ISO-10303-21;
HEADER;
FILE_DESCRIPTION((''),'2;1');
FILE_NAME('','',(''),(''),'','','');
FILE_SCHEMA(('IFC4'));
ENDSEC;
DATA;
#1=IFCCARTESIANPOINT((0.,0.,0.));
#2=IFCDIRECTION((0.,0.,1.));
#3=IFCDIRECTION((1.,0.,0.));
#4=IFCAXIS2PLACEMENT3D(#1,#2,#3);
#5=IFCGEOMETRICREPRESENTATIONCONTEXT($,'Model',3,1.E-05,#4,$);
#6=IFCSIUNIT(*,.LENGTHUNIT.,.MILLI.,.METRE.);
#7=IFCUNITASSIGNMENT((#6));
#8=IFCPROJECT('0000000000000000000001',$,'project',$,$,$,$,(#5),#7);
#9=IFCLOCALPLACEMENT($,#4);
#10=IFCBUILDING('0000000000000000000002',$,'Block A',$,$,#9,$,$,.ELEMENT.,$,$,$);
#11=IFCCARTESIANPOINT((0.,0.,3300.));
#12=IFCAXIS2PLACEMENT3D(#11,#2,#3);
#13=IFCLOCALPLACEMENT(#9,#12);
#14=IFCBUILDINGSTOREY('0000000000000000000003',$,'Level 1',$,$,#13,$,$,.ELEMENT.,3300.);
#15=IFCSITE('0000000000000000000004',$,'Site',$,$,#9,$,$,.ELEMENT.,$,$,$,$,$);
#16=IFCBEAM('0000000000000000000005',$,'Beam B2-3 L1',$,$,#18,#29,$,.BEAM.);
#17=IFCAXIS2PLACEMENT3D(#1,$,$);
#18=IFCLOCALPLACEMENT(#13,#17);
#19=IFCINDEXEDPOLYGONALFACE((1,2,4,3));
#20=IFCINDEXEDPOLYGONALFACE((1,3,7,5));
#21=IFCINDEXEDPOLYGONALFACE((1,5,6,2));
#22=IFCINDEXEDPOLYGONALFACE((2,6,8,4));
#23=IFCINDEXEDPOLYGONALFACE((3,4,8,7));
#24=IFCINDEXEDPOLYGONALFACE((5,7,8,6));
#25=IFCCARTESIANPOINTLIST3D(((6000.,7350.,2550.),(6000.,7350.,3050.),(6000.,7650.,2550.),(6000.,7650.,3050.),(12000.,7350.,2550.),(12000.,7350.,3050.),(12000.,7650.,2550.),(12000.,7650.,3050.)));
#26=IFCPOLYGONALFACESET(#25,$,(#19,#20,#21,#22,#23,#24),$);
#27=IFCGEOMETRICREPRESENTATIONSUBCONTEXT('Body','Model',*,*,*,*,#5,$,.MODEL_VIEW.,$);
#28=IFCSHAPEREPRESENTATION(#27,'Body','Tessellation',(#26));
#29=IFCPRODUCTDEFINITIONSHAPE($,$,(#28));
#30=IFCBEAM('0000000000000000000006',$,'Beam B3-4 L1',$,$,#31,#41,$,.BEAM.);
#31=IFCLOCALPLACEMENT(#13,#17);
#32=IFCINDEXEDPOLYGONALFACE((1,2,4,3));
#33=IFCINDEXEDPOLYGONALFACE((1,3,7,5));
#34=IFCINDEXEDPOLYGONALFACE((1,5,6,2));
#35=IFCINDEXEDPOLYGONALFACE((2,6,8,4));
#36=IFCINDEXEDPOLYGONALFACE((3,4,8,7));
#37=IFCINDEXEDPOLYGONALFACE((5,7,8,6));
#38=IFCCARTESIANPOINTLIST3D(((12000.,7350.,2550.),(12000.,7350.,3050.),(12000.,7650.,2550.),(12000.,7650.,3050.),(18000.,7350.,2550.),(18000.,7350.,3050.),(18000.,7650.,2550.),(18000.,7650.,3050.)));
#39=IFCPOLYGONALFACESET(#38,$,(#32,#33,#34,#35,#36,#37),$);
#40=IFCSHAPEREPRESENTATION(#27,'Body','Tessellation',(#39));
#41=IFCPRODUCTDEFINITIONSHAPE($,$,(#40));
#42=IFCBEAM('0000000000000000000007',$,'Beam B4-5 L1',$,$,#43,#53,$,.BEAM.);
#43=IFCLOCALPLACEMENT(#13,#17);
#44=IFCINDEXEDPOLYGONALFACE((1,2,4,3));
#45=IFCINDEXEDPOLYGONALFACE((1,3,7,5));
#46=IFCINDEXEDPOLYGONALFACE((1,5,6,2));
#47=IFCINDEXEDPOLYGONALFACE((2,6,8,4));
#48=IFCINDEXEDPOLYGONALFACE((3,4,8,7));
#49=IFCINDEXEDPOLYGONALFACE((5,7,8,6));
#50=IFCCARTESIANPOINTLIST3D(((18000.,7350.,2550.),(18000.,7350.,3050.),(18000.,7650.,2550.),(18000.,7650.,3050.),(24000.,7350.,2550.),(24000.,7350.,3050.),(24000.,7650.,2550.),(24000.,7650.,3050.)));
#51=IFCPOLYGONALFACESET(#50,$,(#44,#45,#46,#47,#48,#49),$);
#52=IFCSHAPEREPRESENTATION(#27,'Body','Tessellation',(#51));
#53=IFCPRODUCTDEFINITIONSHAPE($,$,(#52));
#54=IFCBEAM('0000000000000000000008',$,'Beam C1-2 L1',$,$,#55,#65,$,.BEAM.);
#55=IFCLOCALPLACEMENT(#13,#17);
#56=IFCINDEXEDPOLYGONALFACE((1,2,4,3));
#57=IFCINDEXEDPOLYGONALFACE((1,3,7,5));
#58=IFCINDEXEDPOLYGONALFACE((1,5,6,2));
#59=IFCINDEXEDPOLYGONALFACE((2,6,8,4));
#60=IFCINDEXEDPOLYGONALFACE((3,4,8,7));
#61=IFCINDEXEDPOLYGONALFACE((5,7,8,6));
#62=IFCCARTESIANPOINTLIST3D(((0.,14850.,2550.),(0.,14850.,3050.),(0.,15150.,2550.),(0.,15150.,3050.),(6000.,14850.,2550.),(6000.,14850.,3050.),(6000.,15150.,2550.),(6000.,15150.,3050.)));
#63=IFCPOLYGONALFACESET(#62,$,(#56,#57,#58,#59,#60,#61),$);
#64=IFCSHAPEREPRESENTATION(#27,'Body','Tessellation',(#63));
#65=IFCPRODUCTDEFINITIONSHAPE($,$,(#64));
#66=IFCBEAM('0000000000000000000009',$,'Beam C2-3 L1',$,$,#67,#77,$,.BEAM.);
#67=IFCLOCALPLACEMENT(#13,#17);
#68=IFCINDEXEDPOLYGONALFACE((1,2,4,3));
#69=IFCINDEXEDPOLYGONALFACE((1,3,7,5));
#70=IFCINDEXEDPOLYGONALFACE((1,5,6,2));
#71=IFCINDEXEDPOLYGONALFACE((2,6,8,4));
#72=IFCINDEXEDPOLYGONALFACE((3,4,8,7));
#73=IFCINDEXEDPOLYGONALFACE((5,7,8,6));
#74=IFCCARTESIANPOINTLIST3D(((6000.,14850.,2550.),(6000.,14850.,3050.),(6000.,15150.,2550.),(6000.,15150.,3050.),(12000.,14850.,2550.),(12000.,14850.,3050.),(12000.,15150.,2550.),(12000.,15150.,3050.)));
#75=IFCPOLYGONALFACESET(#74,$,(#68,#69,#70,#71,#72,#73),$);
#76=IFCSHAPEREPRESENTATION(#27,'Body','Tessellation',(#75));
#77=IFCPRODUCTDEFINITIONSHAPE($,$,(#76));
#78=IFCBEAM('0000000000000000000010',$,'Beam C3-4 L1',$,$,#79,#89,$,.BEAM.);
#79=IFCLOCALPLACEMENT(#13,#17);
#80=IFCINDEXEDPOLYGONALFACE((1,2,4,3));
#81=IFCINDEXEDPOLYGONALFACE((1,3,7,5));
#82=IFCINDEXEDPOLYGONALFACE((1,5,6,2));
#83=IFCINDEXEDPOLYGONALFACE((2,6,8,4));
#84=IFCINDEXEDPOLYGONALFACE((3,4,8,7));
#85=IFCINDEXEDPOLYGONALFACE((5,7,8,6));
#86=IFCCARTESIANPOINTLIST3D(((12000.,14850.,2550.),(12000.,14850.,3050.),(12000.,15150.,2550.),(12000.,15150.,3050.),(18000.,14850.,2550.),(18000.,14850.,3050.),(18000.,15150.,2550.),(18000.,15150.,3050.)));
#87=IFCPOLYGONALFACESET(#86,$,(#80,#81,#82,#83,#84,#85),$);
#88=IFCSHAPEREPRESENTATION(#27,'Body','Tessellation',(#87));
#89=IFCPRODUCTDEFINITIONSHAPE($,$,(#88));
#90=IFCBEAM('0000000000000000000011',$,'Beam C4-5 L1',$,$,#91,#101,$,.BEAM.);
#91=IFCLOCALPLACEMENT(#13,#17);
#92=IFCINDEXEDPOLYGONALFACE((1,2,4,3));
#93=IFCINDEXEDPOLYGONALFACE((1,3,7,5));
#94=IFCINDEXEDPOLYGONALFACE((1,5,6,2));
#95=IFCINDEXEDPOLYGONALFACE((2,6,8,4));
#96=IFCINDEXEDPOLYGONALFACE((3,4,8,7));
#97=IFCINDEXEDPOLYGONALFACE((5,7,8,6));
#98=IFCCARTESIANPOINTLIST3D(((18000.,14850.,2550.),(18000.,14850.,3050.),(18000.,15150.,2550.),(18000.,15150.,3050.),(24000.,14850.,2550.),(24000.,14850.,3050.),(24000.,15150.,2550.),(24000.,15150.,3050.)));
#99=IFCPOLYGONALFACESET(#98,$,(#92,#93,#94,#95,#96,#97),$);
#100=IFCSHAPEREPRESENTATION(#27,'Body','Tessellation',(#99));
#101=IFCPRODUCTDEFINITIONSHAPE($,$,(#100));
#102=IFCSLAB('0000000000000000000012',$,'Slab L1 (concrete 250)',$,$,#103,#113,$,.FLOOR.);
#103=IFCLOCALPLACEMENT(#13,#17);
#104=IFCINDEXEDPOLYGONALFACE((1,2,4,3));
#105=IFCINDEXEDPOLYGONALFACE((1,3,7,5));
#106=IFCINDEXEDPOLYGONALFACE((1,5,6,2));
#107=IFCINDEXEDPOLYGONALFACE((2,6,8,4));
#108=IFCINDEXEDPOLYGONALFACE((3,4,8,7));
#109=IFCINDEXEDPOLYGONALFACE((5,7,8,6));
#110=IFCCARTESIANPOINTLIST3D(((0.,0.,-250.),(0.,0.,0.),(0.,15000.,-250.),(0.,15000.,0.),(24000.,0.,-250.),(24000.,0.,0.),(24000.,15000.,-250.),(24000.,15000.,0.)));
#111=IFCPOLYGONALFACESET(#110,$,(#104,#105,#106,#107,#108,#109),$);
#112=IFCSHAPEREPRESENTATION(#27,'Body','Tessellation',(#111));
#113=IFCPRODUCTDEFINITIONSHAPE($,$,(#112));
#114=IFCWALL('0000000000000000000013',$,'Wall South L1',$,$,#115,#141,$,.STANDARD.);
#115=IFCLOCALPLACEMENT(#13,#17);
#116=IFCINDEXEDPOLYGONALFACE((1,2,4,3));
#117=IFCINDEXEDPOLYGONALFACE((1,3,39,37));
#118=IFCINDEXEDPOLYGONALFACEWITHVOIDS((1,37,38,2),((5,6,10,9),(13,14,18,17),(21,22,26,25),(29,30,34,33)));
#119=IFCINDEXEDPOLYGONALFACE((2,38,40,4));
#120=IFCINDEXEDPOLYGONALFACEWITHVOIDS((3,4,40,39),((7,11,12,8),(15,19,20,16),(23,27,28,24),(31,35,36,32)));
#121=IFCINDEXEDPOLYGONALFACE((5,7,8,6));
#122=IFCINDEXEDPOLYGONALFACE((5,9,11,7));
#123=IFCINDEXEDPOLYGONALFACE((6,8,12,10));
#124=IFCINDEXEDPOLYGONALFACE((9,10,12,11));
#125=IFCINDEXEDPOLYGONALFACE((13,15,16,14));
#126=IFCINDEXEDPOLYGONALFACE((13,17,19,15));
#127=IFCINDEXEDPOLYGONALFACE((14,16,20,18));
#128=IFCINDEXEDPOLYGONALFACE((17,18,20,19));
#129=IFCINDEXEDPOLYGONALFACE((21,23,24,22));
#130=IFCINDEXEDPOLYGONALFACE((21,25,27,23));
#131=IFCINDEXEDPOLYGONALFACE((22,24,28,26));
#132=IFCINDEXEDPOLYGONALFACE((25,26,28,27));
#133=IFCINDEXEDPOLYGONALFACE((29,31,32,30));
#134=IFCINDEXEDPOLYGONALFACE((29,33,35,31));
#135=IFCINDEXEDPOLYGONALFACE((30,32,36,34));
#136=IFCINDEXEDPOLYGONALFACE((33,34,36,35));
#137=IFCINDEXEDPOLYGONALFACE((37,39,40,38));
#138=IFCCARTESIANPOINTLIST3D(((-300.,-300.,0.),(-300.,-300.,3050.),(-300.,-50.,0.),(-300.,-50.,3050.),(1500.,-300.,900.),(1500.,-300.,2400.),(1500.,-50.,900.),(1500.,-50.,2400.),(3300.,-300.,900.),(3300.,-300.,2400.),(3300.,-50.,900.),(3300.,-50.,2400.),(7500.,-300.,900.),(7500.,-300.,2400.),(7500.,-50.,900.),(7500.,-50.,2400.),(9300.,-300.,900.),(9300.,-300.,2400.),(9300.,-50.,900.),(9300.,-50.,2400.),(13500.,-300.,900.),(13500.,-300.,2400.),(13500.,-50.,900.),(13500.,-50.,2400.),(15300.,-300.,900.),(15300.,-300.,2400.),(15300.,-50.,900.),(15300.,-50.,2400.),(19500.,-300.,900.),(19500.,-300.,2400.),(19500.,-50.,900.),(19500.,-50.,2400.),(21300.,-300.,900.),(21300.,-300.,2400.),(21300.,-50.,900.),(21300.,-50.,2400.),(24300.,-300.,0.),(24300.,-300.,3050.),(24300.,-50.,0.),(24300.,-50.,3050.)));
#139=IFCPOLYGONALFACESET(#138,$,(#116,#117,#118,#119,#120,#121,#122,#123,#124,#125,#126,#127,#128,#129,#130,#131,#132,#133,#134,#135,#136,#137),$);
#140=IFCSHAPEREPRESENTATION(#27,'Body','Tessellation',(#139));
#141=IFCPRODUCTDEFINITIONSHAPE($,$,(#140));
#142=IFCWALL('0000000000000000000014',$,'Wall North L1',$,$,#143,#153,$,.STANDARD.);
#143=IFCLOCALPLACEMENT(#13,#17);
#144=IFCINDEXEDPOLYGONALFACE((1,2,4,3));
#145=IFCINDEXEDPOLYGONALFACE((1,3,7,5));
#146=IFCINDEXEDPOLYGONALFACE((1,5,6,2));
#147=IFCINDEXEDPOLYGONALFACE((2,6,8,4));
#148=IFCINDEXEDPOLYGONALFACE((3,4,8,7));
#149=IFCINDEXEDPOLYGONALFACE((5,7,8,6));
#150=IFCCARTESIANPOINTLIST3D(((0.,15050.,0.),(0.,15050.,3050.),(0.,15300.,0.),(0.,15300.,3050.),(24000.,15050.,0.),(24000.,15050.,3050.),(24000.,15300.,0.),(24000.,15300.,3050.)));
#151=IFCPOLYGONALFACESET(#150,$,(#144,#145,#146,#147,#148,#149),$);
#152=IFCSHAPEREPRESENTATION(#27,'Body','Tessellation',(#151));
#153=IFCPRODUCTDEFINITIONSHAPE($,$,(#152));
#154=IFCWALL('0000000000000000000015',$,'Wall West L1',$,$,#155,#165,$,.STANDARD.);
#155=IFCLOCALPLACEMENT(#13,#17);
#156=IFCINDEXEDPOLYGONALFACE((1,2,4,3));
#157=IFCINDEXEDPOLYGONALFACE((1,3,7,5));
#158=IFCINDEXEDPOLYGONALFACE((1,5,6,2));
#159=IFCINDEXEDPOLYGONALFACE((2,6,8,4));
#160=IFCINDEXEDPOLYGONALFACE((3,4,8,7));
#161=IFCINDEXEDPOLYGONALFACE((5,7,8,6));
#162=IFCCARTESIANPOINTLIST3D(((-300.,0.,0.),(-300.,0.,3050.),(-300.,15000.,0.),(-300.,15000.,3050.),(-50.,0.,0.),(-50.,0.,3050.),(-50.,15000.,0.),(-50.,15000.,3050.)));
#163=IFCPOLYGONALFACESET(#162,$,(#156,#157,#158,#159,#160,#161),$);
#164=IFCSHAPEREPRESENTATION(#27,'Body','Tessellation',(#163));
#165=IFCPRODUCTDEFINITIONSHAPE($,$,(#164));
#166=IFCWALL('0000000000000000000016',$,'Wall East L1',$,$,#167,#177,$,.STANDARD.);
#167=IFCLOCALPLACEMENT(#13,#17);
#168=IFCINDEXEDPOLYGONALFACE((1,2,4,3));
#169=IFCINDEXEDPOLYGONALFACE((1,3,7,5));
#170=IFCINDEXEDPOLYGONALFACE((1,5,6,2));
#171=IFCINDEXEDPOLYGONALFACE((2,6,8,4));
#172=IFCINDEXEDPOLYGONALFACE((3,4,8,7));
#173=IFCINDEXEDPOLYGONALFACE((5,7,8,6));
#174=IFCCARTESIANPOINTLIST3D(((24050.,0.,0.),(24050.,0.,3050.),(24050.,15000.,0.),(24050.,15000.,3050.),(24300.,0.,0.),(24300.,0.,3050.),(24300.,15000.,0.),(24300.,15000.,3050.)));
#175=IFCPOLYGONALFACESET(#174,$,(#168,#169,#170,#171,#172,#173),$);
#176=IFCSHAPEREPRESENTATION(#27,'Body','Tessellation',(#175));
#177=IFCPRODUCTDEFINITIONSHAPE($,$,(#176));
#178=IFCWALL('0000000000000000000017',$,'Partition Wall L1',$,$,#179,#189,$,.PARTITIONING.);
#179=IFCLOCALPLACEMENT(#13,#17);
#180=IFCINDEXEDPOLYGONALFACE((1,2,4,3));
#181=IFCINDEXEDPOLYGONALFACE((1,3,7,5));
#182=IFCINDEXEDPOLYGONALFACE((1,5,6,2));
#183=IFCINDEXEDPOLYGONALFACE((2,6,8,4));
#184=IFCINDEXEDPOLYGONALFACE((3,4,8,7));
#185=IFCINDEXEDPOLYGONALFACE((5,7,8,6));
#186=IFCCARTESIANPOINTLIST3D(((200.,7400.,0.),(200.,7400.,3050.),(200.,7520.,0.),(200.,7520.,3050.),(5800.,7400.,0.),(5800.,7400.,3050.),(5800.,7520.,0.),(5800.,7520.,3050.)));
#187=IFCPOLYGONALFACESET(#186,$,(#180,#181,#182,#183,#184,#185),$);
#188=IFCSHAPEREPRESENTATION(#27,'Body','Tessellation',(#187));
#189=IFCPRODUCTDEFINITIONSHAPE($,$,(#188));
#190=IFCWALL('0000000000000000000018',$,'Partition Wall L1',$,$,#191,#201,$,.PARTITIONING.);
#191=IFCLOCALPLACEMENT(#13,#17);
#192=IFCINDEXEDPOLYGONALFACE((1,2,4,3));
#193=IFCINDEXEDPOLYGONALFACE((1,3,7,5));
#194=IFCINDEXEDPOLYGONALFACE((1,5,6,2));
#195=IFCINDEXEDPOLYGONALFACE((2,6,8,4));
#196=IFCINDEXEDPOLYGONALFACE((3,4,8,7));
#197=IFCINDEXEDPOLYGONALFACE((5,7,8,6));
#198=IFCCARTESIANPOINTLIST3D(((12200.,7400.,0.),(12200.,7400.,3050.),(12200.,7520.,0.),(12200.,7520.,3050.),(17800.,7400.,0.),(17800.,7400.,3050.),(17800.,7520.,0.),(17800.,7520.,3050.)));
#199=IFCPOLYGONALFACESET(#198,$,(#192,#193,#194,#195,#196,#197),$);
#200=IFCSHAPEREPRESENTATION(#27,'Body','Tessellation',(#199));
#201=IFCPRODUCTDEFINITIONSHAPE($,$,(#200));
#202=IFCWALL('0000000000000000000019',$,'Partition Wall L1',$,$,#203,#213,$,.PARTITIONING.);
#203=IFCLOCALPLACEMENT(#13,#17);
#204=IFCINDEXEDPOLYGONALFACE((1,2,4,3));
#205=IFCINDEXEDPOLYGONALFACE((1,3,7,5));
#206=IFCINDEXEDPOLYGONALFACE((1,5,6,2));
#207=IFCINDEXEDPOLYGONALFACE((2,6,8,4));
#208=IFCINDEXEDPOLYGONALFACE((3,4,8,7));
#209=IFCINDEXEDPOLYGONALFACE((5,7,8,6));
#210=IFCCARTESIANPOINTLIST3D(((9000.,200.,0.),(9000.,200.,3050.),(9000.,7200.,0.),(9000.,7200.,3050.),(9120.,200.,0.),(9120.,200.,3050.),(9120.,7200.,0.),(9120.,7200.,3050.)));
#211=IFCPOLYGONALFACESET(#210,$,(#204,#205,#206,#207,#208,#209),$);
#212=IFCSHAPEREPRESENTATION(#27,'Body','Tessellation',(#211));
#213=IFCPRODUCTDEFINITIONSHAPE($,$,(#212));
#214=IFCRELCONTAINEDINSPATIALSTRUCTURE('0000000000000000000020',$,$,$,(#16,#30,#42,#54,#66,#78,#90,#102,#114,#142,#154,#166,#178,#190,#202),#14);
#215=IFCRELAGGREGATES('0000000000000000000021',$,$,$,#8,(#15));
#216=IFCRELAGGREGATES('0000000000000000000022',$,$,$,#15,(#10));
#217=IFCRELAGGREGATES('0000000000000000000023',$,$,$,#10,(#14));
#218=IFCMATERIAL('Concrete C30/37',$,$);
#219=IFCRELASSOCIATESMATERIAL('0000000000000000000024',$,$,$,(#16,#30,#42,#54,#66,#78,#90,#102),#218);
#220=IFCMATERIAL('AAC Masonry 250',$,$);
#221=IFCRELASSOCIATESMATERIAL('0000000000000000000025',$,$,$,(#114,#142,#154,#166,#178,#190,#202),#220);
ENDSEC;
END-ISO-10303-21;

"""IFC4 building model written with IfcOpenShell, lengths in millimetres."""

from ifc_helpers import new_model, si_unit, frame, frame_2d, origin_with_axes, place, context, subcontext, project, spatial, polyline, rectangle, outline, extrude, material, element, save


model = new_model("IFC4")

# Units and contexts
model_context = context("Model", 3, precision=1e-05, world=origin_with_axes())
body_context = subcontext(model_context, "Body", "Model", "MODEL_VIEW")
ifc_project = project(units=[si_unit("LENGTHUNIT", "METRE", prefix="MILLI")], contexts=[model_context])

# Site, building, storey
placement = place(None, origin_with_axes())
site = spatial("IfcSite", under=ifc_project, at=placement, Name="Site", CompositionType="ELEMENT")
building = spatial("IfcBuilding", under=site, at=placement, Name="Block A", CompositionType="ELEMENT")
storey_placement = place(placement, frame((0.0, 0.0, 3300.0), z_axis=(0.0, 0.0, 1.0), x_axis=(1.0, 0.0, 0.0)))
storey = spatial("IfcBuildingStorey", under=building, at=storey_placement, Name="Level 1", CompositionType="ELEMENT", Elevation=3300.0)

# Shared definitions
ifc_material_1 = material(Name="Concrete C30/37")

# Beams
for number, where, z_axis, x_axis, name in (
    (1, (6000.0, 7500.0, 5850.0), (0.0, 0.0, 1.0), (1.0, 0.0, 0.0), "Beam B2-3 L1"),
    (2, (12000.0, 7500.0, 5850.0), (0.0, 0.0, 1.0), (1.0, 0.0, 0.0), "Beam B3-4 L1"),
    (3, (18000.0, 7500.0, 5850.0), (0.0, 0.0, 1.0), (1.0, 0.0, 0.0), "Beam B4-5 L1"),
    (4, (0.0, 15000.0, 5850.0), (0.0, 0.0, 1.0), (1.0, 0.0, 0.0), "Beam C1-2 L1"),
    (5, (6000.0, 15000.0, 5850.0), (0.0, 0.0, 1.0), (1.0, 0.0, 0.0), "Beam C2-3 L1"),
    (6, (12000.0, 15000.0, 5850.0), (0.0, 0.0, 1.0), (1.0, 0.0, 0.0), "Beam C3-4 L1"),
    (7, (18000.0, 15000.0, 5850.0), (0.0, 0.0, 1.0), (1.0, 0.0, 0.0), "Beam C4-5 L1"),
):
    element("IfcBeam", number, at=place(placement, frame(where, z_axis=z_axis, x_axis=x_axis)), inside=storey, material=ifc_material_1, Name=name, PredefinedType="BEAM", context=body_context, shape_type="SweptSolid", body=[
        extrude(rectangle(XDim=6000.0, YDim=300.0, at=frame_2d((3000.0, 0.0))), origin_with_axes(), (0.0, 0.0, 1.0), 500.0),
    ])

# Slab
slab_placement = place(placement, frame((0.0, 0.0, 3050.0), z_axis=(0.0, 0.0, 1.0), x_axis=(1.0, 0.0, 0.0)))
element("IfcSlab", 8, at=slab_placement, inside=storey, material=ifc_material_1, Name="Slab L1 (concrete 250)", PredefinedType="FLOOR", context=body_context, shape_type="SweptSolid", body=[
    extrude(rectangle(XDim=24000.0, YDim=15000.0, at=frame_2d((12000.0, 7500.0))), origin_with_axes(), (0.0, 0.0, 1.0), 250.0),
])

# Walls
ifc_material_2 = material(Name="AAC Masonry 250")
wall_1_placement = place(placement, frame((0.0, 0.0, 3300.0), z_axis=(0.0, 0.0, 1.0), x_axis=(1.0, 0.0, 0.0)))
element("IfcWall", 9, at=wall_1_placement, inside=storey, material=ifc_material_2, Name="Wall South L1", PredefinedType="STANDARD", context=body_context, shape_type="SweptSolid", body=[
    extrude(outline(polyline([(-300.0, 0.0), (24300.0, 0.0), (24300.0, 3050.0), (-300.0, 3050.0), (-300.0, 0.0)]), holes=[polyline([(1500.0, 900.0), (3300.0, 900.0), (3300.0, 2400.0), (1500.0, 2400.0), (1500.0, 900.0)]), polyline([(7500.0, 900.0), (9300.0, 900.0), (9300.0, 2400.0), (7500.0, 2400.0), (7500.0, 900.0)]), polyline([(13500.0, 900.0), (15300.0, 900.0), (15300.0, 2400.0), (13500.0, 2400.0), (13500.0, 900.0)]), polyline([(19500.0, 900.0), (21300.0, 900.0), (21300.0, 2400.0), (19500.0, 2400.0), (19500.0, 900.0)])]), frame((0.0, -50.0, 0.0), z_axis=(0.0, -1.0, 0.0), x_axis=(1.0, 0.0, 0.0)), (0.0, 0.0, 1.0), 250.0),
])
wall_2_placement = place(placement, frame((0.0, 15050.0, 3300.0), z_axis=(0.0, 0.0, 1.0), x_axis=(1.0, 0.0, 0.0)))
element("IfcWall", 10, at=wall_2_placement, inside=storey, material=ifc_material_2, Name="Wall North L1", PredefinedType="STANDARD", context=body_context, shape_type="SweptSolid", body=[
    extrude(rectangle(XDim=24000.0, YDim=250.0, at=frame_2d((12000.0, 125.0))), origin_with_axes(), (0.0, 0.0, 1.0), 3050.0),
])
for number, where, z_axis, x_axis, name in (
    (11, (-300.0, 0.0, 3300.0), (0.0, 0.0, 1.0), (1.0, 0.0, 0.0), "Wall West L1"),
    (12, (24050.0, 0.0, 3300.0), (0.0, 0.0, 1.0), (1.0, 0.0, 0.0), "Wall East L1"),
):
    element("IfcWall", number, at=place(placement, frame(where, z_axis=z_axis, x_axis=x_axis)), inside=storey, material=ifc_material_2, Name=name, PredefinedType="STANDARD", context=body_context, shape_type="SweptSolid", body=[
        extrude(rectangle(XDim=250.0, YDim=15000.0, at=frame_2d((125.0, 7500.0))), origin_with_axes(), (0.0, 0.0, 1.0), 3050.0),
    ])
for number, where, z_axis, x_axis, name in (
    (13, (200.0, 7400.0, 3300.0), (0.0, 0.0, 1.0), (1.0, 0.0, 0.0), "Partition Wall L1"),
    (14, (12200.0, 7400.0, 3300.0), (0.0, 0.0, 1.0), (1.0, 0.0, 0.0), "Partition Wall L1"),
):
    element("IfcWall", number, at=place(placement, frame(where, z_axis=z_axis, x_axis=x_axis)), inside=storey, material=ifc_material_2, Name=name, PredefinedType="PARTITIONING", context=body_context, shape_type="SweptSolid", body=[
        extrude(rectangle(XDim=5600.0, YDim=120.0, at=frame_2d((2800.0, 60.0))), origin_with_axes(), (0.0, 0.0, 1.0), 3050.0),
    ])
wall_3_placement = place(placement, frame((9000.0, 200.0, 3300.0), z_axis=(0.0, 0.0, 1.0), x_axis=(1.0, 0.0, 0.0)))
element("IfcWall", 15, at=wall_3_placement, inside=storey, material=ifc_material_2, Name="Partition Wall L1", PredefinedType="PARTITIONING", context=body_context, shape_type="SweptSolid", body=[
    extrude(rectangle(XDim=120.0, YDim=7000.0, at=frame_2d((60.0, 3500.0))), origin_with_axes(), (0.0, 0.0, 1.0), 3050.0),
])

save(model, "model.ifc")
